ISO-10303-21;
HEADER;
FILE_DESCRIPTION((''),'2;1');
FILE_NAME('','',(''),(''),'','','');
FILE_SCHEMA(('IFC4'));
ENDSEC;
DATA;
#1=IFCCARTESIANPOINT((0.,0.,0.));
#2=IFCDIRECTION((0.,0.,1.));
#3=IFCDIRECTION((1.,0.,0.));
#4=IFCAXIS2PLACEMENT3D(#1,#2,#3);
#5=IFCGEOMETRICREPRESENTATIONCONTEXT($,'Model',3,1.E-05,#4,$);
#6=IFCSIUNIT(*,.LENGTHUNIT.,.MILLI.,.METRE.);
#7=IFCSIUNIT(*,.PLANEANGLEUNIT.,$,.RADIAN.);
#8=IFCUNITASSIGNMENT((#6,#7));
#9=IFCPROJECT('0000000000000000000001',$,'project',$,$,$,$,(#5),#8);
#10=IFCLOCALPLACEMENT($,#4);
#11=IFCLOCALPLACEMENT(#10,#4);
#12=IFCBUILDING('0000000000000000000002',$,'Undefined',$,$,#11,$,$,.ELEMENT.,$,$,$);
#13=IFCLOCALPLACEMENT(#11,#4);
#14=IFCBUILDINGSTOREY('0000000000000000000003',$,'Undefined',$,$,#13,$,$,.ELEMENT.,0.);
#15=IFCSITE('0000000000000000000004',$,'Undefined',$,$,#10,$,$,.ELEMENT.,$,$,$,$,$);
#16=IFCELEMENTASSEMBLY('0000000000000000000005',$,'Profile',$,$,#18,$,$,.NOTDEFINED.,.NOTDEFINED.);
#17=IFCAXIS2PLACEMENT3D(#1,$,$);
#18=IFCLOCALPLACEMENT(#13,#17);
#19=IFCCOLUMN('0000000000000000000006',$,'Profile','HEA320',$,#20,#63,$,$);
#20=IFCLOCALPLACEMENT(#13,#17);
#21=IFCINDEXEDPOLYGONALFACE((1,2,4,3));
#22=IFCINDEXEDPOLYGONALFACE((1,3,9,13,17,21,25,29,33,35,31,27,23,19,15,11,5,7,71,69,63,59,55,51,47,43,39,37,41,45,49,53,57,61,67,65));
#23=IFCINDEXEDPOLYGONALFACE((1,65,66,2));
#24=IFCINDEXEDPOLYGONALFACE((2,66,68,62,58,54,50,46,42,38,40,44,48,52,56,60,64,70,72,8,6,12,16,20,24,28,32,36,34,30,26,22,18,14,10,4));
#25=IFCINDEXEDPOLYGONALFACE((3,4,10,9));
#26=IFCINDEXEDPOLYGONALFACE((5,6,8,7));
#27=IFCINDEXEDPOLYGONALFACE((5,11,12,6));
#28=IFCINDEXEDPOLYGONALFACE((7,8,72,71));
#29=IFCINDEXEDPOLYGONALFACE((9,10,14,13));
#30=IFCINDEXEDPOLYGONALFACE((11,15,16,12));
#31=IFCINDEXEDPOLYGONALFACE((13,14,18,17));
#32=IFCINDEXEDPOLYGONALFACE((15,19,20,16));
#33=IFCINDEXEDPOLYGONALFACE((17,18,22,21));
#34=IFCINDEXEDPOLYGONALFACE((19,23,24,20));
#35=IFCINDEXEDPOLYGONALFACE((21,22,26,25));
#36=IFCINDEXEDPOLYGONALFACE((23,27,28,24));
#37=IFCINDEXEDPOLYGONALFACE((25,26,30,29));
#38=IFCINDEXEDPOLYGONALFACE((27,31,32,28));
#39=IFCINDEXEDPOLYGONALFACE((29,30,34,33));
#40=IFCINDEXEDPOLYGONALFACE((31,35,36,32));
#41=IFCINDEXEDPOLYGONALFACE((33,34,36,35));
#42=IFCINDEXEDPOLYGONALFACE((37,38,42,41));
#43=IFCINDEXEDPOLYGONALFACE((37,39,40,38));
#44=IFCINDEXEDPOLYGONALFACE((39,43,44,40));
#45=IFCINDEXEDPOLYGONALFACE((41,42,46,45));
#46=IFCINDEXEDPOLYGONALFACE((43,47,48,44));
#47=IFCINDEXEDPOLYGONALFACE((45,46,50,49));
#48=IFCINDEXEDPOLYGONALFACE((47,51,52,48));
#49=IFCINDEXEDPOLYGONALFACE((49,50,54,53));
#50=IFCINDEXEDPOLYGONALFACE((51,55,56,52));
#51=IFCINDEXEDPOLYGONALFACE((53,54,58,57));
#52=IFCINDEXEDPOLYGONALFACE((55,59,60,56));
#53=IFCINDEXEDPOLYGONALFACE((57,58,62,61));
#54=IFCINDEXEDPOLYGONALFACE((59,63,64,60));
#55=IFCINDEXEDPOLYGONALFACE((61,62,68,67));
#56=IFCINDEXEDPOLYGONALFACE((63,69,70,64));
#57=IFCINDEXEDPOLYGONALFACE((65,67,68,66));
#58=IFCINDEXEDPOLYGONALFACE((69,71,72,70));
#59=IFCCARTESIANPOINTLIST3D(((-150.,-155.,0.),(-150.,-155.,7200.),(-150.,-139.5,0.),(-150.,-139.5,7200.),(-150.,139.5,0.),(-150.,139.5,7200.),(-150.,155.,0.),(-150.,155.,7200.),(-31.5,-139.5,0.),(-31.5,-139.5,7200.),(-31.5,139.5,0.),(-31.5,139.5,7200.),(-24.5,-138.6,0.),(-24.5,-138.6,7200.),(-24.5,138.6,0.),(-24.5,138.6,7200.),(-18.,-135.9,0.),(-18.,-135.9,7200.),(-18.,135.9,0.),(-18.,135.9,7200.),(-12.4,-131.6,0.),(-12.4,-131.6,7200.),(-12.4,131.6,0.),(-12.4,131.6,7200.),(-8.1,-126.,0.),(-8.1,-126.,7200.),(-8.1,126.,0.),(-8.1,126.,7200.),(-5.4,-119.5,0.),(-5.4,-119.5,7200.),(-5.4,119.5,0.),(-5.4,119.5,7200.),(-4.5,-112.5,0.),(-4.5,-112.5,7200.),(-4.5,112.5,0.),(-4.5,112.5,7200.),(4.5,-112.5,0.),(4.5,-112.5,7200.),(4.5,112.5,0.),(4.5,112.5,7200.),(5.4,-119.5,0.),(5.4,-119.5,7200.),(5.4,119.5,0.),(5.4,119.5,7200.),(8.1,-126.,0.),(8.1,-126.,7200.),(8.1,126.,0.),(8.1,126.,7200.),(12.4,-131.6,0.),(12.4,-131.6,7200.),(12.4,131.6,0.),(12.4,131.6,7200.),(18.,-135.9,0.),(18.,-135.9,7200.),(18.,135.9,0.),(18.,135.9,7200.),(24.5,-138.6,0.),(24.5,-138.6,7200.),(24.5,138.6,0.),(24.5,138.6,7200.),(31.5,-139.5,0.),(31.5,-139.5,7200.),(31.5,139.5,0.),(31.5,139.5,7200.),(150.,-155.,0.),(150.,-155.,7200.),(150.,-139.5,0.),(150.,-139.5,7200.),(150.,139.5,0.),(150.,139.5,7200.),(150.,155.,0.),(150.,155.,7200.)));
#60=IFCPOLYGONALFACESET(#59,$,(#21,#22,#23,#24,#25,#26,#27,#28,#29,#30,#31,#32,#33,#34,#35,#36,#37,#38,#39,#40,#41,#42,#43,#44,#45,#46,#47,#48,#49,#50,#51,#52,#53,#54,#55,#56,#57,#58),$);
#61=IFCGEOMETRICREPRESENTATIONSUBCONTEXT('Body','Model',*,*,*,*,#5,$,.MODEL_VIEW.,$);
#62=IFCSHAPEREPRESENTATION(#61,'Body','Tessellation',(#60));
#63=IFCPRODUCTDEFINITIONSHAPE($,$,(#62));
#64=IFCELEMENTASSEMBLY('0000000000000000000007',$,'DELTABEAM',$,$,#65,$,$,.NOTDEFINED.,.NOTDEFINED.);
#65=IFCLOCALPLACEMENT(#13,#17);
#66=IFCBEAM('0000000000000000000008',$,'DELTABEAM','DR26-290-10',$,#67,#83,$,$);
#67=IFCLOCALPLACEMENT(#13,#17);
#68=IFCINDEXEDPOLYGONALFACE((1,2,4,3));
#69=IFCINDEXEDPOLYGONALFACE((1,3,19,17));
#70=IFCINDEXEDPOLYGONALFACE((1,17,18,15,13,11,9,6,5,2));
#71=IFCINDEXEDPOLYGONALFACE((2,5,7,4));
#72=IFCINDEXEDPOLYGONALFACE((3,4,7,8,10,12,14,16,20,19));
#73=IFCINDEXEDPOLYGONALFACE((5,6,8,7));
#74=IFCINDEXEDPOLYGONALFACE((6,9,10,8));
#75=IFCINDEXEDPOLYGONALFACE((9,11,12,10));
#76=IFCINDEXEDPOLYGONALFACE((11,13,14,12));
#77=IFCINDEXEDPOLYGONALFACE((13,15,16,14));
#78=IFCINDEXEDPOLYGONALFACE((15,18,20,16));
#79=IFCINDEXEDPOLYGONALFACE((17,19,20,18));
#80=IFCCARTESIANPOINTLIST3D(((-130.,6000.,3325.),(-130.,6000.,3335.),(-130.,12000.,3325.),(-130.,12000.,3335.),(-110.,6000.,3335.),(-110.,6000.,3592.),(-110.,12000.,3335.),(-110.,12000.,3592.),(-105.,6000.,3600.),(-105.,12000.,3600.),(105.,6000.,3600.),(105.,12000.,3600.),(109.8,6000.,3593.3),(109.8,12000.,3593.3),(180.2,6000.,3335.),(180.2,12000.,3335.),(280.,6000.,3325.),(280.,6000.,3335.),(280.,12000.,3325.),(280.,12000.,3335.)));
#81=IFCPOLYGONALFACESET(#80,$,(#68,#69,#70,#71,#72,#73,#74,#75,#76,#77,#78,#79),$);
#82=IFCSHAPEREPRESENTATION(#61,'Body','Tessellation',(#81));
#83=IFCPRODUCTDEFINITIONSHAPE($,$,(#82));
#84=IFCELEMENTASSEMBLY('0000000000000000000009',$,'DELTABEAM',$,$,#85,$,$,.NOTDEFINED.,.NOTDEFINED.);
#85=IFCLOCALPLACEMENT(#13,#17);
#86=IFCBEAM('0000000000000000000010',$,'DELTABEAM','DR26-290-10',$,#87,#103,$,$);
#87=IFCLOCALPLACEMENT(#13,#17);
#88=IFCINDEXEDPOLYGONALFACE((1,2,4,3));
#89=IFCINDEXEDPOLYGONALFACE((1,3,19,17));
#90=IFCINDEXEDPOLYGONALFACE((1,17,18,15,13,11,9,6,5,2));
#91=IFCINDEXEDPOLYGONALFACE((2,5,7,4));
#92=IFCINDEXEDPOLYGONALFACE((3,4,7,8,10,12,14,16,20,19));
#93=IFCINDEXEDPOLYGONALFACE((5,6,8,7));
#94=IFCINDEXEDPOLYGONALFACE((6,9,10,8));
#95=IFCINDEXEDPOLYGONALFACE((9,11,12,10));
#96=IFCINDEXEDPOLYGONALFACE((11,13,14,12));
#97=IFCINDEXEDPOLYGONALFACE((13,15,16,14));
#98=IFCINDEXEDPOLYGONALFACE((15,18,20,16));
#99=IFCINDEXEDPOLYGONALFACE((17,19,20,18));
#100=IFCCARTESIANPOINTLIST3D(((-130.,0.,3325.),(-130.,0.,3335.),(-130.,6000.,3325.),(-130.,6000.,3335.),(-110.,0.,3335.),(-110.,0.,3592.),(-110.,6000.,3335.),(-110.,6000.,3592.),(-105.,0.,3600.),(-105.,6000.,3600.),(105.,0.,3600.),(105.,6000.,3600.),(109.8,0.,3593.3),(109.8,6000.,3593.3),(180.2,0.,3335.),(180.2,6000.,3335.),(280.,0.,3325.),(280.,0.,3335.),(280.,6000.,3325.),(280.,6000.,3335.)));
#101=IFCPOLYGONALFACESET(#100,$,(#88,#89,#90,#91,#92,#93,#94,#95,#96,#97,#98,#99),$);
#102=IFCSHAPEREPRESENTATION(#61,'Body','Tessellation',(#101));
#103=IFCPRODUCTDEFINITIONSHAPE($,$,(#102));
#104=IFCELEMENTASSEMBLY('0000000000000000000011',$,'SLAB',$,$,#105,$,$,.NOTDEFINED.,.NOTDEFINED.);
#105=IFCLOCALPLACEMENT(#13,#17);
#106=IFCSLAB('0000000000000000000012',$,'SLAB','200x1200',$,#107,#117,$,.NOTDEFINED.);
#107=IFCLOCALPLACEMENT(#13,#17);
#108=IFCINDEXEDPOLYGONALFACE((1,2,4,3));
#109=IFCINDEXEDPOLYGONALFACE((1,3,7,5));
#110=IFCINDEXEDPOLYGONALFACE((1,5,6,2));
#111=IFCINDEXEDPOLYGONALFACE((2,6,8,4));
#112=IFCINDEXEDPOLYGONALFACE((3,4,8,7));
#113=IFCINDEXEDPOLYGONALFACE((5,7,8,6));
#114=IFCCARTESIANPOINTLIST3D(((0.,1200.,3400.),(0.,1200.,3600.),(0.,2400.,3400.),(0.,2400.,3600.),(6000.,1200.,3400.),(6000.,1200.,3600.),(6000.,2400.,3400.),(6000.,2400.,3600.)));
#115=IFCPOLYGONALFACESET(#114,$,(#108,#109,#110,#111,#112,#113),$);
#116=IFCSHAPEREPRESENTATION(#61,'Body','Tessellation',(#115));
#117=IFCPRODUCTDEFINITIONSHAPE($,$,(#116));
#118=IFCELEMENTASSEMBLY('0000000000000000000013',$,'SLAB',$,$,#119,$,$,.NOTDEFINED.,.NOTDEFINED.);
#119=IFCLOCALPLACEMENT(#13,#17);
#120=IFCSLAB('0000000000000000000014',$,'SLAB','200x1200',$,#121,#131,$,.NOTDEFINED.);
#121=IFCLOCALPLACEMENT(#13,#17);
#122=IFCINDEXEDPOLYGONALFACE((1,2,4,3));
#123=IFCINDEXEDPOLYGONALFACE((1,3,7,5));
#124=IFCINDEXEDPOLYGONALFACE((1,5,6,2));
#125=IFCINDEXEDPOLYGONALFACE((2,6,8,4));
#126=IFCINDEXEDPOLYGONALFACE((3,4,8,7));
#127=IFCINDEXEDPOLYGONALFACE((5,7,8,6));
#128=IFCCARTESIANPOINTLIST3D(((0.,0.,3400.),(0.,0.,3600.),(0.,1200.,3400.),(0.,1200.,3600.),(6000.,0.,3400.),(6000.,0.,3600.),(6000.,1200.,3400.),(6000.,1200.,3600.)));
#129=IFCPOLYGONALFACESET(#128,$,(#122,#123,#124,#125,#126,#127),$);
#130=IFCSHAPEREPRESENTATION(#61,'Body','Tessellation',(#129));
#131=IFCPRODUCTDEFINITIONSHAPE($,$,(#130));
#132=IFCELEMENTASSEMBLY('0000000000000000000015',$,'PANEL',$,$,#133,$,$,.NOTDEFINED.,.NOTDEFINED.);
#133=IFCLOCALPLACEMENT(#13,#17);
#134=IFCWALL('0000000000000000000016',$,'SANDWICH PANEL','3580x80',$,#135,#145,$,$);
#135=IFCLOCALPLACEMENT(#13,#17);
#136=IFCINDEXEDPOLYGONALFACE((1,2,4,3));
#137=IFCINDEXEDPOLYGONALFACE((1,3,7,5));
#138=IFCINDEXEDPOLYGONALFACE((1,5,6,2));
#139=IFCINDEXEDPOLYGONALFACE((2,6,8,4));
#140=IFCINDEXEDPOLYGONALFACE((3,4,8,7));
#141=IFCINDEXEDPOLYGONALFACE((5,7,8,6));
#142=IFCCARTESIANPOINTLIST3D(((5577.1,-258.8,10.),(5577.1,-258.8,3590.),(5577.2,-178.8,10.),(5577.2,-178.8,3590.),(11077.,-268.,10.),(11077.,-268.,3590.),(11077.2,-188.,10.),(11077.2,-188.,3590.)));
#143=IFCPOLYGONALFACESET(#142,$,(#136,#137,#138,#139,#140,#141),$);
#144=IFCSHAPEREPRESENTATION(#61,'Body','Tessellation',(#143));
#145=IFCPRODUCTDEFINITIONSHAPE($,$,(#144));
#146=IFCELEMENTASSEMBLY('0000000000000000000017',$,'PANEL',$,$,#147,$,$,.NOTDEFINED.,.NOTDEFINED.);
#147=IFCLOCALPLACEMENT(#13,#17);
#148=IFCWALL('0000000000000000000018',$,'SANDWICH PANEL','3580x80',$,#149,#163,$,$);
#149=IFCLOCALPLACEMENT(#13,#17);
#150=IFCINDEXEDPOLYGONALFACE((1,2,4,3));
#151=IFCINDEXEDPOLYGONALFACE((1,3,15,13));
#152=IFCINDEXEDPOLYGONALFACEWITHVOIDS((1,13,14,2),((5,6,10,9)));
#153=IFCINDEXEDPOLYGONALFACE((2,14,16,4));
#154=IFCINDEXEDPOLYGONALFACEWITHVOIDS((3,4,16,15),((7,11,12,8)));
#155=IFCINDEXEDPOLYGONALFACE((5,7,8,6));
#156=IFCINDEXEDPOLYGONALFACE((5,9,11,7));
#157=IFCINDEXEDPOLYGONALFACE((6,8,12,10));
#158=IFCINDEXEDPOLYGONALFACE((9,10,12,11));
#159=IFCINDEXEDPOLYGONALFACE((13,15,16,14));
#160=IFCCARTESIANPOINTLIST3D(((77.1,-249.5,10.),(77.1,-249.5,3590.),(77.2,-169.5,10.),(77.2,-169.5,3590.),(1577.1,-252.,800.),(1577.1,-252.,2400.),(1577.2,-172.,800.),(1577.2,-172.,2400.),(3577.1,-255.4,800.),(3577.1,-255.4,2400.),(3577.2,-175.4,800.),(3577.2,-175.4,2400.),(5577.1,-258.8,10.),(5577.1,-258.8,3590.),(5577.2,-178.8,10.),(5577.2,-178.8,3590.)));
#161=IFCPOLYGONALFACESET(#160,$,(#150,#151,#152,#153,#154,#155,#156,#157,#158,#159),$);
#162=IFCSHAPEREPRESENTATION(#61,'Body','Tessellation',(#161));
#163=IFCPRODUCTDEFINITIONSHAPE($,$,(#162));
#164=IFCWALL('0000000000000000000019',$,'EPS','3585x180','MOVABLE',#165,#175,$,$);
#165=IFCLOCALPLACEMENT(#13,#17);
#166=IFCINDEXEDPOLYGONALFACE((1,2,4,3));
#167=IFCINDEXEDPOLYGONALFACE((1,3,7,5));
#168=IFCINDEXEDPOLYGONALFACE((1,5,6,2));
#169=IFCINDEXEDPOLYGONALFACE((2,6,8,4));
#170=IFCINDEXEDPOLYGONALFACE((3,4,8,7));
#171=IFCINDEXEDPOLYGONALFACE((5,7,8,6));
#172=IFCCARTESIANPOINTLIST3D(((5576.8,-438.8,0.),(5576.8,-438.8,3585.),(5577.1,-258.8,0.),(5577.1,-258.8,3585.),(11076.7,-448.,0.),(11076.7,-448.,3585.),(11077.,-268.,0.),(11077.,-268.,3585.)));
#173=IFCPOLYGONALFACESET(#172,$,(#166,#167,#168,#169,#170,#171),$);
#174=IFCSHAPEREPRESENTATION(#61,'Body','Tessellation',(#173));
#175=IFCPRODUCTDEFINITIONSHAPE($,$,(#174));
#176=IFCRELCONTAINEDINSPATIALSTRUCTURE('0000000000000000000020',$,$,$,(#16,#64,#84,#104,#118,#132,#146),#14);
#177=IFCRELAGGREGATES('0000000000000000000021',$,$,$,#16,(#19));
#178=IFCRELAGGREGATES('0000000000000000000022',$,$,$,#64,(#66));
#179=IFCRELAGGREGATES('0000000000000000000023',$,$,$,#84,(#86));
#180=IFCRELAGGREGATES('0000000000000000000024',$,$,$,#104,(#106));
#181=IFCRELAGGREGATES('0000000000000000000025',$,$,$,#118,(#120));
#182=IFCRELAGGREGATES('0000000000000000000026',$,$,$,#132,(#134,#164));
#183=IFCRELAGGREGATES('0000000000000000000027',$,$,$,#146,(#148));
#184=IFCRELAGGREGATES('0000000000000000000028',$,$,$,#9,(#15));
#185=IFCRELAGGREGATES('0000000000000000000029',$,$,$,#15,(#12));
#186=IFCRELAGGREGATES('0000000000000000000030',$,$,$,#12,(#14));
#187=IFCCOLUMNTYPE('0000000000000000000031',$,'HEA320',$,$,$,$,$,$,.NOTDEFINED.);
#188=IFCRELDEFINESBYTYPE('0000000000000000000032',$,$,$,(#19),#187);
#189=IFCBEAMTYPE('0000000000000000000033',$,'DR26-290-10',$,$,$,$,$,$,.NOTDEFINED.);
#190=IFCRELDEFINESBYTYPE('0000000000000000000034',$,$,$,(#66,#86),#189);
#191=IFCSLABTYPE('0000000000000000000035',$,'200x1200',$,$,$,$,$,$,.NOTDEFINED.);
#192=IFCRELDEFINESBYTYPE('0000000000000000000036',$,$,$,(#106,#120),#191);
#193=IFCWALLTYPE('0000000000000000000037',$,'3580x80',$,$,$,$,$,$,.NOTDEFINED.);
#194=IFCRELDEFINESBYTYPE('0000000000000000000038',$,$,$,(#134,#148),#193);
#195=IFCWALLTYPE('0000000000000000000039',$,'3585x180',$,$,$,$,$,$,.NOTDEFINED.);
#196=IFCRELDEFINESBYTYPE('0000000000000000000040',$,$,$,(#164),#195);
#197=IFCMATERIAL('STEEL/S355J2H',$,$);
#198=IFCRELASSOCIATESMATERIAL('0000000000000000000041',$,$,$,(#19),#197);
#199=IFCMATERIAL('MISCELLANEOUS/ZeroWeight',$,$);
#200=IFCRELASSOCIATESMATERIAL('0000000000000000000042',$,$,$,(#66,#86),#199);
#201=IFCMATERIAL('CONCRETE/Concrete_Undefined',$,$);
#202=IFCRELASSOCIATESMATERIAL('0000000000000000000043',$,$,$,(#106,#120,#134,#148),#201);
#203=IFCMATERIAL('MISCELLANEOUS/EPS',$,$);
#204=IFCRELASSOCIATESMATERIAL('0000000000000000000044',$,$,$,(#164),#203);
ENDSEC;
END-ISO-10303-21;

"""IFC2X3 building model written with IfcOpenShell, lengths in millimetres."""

from ifc_helpers import new_model, si_unit, frame, frame_2d, origin_with_axes, origin_2d_with_axis, place, context, subcontext, project, spatial, polyline, rectangle, i_section, outline, extrude, material, type_object, element, aggregate, save


model = new_model("IFC2X3")

# Units and contexts
model_context = context("Model", 3, precision=1e-05, world=origin_with_axes())
body_context = subcontext(model_context, "Body", "Model", "MODEL_VIEW")
ifc_project = project(units=[si_unit("LENGTHUNIT", "METRE", prefix="MILLI"), si_unit("PLANEANGLEUNIT", "RADIAN")], contexts=[model_context])

# Site, building, storey
site_placement = place(None, origin_with_axes())
site = spatial("IfcSite", under=ifc_project, at=site_placement, Name="Undefined", CompositionType="ELEMENT")
building_placement = place(site_placement, origin_with_axes())
building = spatial("IfcBuilding", under=site, at=building_placement, Name="Undefined", CompositionType="ELEMENT")
storey_placement = place(building_placement, origin_with_axes())
storey = spatial("IfcBuildingStorey", under=building, at=storey_placement, Name="Undefined", CompositionType="ELEMENT", Elevation=0.0)

# Shared definitions
ifc_material_1 = material(Name="CONCRETE/Concrete_Undefined")

# Element assembly, column
ifc_material_2 = material(Name="STEEL/S355J2H")
column_type = type_object("IfcColumnType", Name="HEA320", PredefinedType="NOTDEFINED")
assembly_1_placement = place(storey_placement, origin_with_axes())
assembly_1 = element("IfcElementAssembly", 1, at=assembly_1_placement, inside=storey, Name="Profile", AssemblyPlace="NOTDEFINED", PredefinedType="NOTDEFINED")
column_1_placement = place(assembly_1_placement, frame((0.0, 0.0, 0.0), z_axis=(0.0, 0.0, 1.0), x_axis=(0.0, 1.0, 0.0)))
column_1 = element("IfcColumn", 2, at=column_1_placement, type_object=column_type, material=ifc_material_2, Name="Profile", Description="HEA320", context=body_context, shape_type="SweptSolid", body=[
    extrude(i_section(OverallWidth=300.0, OverallDepth=310.0, WebThickness=9.0, FlangeThickness=15.5, FilletRadius=27.0, at=origin_2d_with_axis()), frame((0.0, 0.0, 7200.0), z_axis=(0.0, 0.0, -1.0), x_axis=(0.0, 1.0, 0.0)), (0.0, 0.0, 1.0), 7200.0),
])
aggregate(assembly_1, [column_1])

# Element assemblies, beams
assembly_2_placement = place(storey_placement, origin_with_axes())
assembly_2 = element("IfcElementAssembly", 3, at=assembly_2_placement, inside=storey, Name="DELTABEAM", AssemblyPlace="NOTDEFINED", PredefinedType="NOTDEFINED")
ifc_material_3 = material(Name="MISCELLANEOUS/ZeroWeight")
beam_type_1 = type_object("IfcBeamType", Name="DR26-290-10", PredefinedType="NOTDEFINED")
beam_1_placement = place(assembly_2_placement, frame((0.0, 6000.0, 3467.5), z_axis=(0.0, 0.0, 1.0), x_axis=(0.0, 1.0, 0.0)))
beam_1 = element("IfcBeam", 4, at=beam_1_placement, type_object=beam_type_1, material=ifc_material_3, Name="DELTABEAM", Description="DR26-290-10", context=body_context, shape_type="SweptSolid", body=[
    extrude(outline(polyline([(-105.0, 120.5), (-105.0, -132.5), (280.0, -132.5), (280.0, -142.5), (-130.0, -142.5), (-130.0, -132.5), (-110.0, -132.5), (-110.0, 124.5), (-105.0, 132.5), (105.0, 132.5), (109.8, 125.8), (180.2, -132.5), (175.0, -132.5), (106.1, 120.5), (-105.0, 120.5)])), frame((6000.0, 0.0, 0.0), z_axis=(-1.0, 0.0, 0.0), x_axis=(0.0, -1.0, 0.0)), (0.0, 0.0, 1.0), 6000.0),
])
aggregate(assembly_2, [beam_1])
assembly_3_placement = place(storey_placement, origin_with_axes())
assembly_3 = element("IfcElementAssembly", 5, at=assembly_3_placement, inside=storey, Name="DELTABEAM", AssemblyPlace="NOTDEFINED", PredefinedType="NOTDEFINED")
beam_2_placement = place(assembly_3_placement, frame((0.0, 0.0, 3467.5), z_axis=(0.0, 0.0, 1.0), x_axis=(0.0, 1.0, 0.0)))
beam_2 = element("IfcBeam", 6, at=beam_2_placement, type_object=beam_type_1, material=ifc_material_3, Name="DELTABEAM", Description="DR26-290-10", context=body_context, shape_type="SweptSolid", body=[
    extrude(outline(polyline([(-105.0, 120.5), (-105.0, -132.5), (280.0, -132.5), (280.0, -142.5), (-130.0, -142.5), (-130.0, -132.5), (-110.0, -132.5), (-110.0, 124.5), (-105.0, 132.5), (105.0, 132.5), (109.8, 125.8), (180.2, -132.5), (175.0, -132.5), (106.1, 120.5), (-105.0, 120.5)])), frame((6000.0, 0.0, 0.0), z_axis=(-1.0, 0.0, 0.0), x_axis=(0.0, -1.0, 0.0)), (0.0, 0.0, 1.0), 6000.0),
])
aggregate(assembly_3, [beam_2])

# Element assemblies, slabs
assembly_4_placement = place(storey_placement, origin_with_axes())
assembly_4 = element("IfcElementAssembly", 7, at=assembly_4_placement, inside=storey, Name="SLAB", AssemblyPlace="NOTDEFINED", PredefinedType="NOTDEFINED")
slab_type = type_object("IfcSlabType", Name="200x1200", PredefinedType="NOTDEFINED")
slab_1_placement = place(assembly_4_placement, frame((6000.0, 1200.0, 3500.0), z_axis=(0.0, 0.0, 1.0), x_axis=(0.0, 1.0, 0.0)))
slab_1 = element("IfcSlab", 8, at=slab_1_placement, type_object=slab_type, material=ifc_material_1, Name="SLAB", Description="200x1200", PredefinedType="NOTDEFINED", context=body_context, shape_type="SweptSolid", body=[
    extrude(outline(polyline([(0.0, 0.0), (1200.0, 0.0), (1200.0, 6000.0), (0.0, 6000.0), (0.0, 0.0)])), frame((0.0, 0.0, -100.0), z_axis=(0.0, 0.0, 1.0), x_axis=(1.0, 0.0, 0.0)), (0.0, 0.0, 1.0), 200.0),
])
aggregate(assembly_4, [slab_1])
assembly_5_placement = place(storey_placement, origin_with_axes())
assembly_5 = element("IfcElementAssembly", 9, at=assembly_5_placement, inside=storey, Name="SLAB", AssemblyPlace="NOTDEFINED", PredefinedType="NOTDEFINED")
slab_2_placement = place(assembly_5_placement, frame((6000.0, 0.0, 3500.0), z_axis=(0.0, 0.0, 1.0), x_axis=(0.0, 1.0, 0.0)))
slab_2 = element("IfcSlab", 10, at=slab_2_placement, type_object=slab_type, material=ifc_material_1, Name="SLAB", Description="200x1200", PredefinedType="NOTDEFINED", context=body_context, shape_type="SweptSolid", body=[
    extrude(outline(polyline([(0.0, 0.0), (1200.0, 0.0), (1200.0, 6000.0), (0.0, 6000.0), (0.0, 0.0)])), frame((0.0, 0.0, -100.0), z_axis=(0.0, 0.0, 1.0), x_axis=(1.0, 0.0, 0.0)), (0.0, 0.0, 1.0), 200.0),
])
aggregate(assembly_5, [slab_2])

# Element assembly, wall
assembly_6_placement = place(storey_placement, origin_with_axes())
assembly_6 = element("IfcElementAssembly", 11, at=assembly_6_placement, inside=storey, Name="PANEL", AssemblyPlace="NOTDEFINED", PredefinedType="NOTDEFINED")
wall_type_1 = type_object("IfcWallType", Name="3580x80", PredefinedType="NOTDEFINED")
wall_1_placement = place(assembly_6_placement, frame((5577.1, -218.8, 10.0), z_axis=(0.0, 0.0, 1.0), x_axis=(0.999999, -0.001684, 0.0)))
wall_1 = element("IfcWall", 12, at=wall_1_placement, type_object=wall_type_1, material=ifc_material_1, Name="SANDWICH PANEL", Description="3580x80", context=body_context, shape_type="SweptSolid", body=[
    extrude(rectangle(XDim=5500.0, YDim=80.0, at=frame_2d((0.0, 2750.0), x_axis=(0.0, -1.0))), frame((0.0, 0.0, 0.0), z_axis=(0.0, 0.0, 1.0), x_axis=(0.0, -1.0, 0.0)), (0.0, 0.0, 1.0), 3580.0),
])

# Element assembly, wall, opening
assembly_7_placement = place(storey_placement, origin_with_axes())
assembly_7 = element("IfcElementAssembly", 13, at=assembly_7_placement, inside=storey, Name="PANEL", AssemblyPlace="NOTDEFINED", PredefinedType="NOTDEFINED")
wall_2_placement = place(assembly_7_placement, frame((77.1, -209.5, 10.0), z_axis=(0.0, 0.0, 1.0), x_axis=(0.999999, -0.001684, 0.0)))
wall_2 = element("IfcWall", 14, at=wall_2_placement, type_object=wall_type_1, material=ifc_material_1, Name="SANDWICH PANEL", Description="3580x80", context=body_context, shape_type="SweptSolid", body=[
    extrude(rectangle(XDim=5500.0, YDim=80.0, at=frame_2d((0.0, 2750.0), x_axis=(0.0, -1.0))), frame((0.0, 0.0, 0.0), z_axis=(0.0, 0.0, 1.0), x_axis=(0.0, -1.0, 0.0)), (0.0, 0.0, 1.0), 3580.0),
])
opening_1_placement = place(assembly_7_placement, frame((77.1, -209.5, 10.0), z_axis=(0.0, 0.0, 1.0), x_axis=(0.999999, -0.001684, 0.0)))
element("IfcOpeningElement", 15, at=opening_1_placement, cuts=wall_2, ObjectType="Recess", context=body_context, shape_type="SweptSolid", body=[
    extrude(outline(polyline([(0.0, 0.0), (2000.0, 0.0), (2000.0, 1600.0), (0.0, 1600.0), (0.0, 0.0)])), frame((1500.0, 90.0, 790.0), z_axis=(0.0, -1.0, 0.0), x_axis=(1.0, 0.0, 0.0)), (0.0, 0.0, 1.0), 180.0),
])

# Wall
ifc_material_4 = material(Name="MISCELLANEOUS/EPS")
wall_type_2 = type_object("IfcWallType", Name="3585x180", PredefinedType="NOTDEFINED")
wall_3_placement = place(assembly_6_placement, frame((5576.9, -348.8, 0.0), z_axis=(0.0, 0.0, 1.0), x_axis=(0.999999, -0.001684, 0.0)))
wall_3 = element("IfcWall", 16, at=wall_3_placement, type_object=wall_type_2, material=ifc_material_4, Name="EPS", Description="3585x180", ObjectType="MOVABLE", context=body_context, shape_type="SweptSolid", body=[
    extrude(rectangle(XDim=5500.0, YDim=180.0, at=frame_2d((0.0, 2750.0), x_axis=(0.0, -1.0))), frame((0.0, 0.0, 0.0), z_axis=(0.0, 0.0, 1.0), x_axis=(0.0, -1.0, 0.0)), (0.0, 0.0, 1.0), 3585.0),
])

aggregate(assembly_6, [wall_1, wall_3])

aggregate(assembly_7, [wall_2])

save(model, "model.ifc")
